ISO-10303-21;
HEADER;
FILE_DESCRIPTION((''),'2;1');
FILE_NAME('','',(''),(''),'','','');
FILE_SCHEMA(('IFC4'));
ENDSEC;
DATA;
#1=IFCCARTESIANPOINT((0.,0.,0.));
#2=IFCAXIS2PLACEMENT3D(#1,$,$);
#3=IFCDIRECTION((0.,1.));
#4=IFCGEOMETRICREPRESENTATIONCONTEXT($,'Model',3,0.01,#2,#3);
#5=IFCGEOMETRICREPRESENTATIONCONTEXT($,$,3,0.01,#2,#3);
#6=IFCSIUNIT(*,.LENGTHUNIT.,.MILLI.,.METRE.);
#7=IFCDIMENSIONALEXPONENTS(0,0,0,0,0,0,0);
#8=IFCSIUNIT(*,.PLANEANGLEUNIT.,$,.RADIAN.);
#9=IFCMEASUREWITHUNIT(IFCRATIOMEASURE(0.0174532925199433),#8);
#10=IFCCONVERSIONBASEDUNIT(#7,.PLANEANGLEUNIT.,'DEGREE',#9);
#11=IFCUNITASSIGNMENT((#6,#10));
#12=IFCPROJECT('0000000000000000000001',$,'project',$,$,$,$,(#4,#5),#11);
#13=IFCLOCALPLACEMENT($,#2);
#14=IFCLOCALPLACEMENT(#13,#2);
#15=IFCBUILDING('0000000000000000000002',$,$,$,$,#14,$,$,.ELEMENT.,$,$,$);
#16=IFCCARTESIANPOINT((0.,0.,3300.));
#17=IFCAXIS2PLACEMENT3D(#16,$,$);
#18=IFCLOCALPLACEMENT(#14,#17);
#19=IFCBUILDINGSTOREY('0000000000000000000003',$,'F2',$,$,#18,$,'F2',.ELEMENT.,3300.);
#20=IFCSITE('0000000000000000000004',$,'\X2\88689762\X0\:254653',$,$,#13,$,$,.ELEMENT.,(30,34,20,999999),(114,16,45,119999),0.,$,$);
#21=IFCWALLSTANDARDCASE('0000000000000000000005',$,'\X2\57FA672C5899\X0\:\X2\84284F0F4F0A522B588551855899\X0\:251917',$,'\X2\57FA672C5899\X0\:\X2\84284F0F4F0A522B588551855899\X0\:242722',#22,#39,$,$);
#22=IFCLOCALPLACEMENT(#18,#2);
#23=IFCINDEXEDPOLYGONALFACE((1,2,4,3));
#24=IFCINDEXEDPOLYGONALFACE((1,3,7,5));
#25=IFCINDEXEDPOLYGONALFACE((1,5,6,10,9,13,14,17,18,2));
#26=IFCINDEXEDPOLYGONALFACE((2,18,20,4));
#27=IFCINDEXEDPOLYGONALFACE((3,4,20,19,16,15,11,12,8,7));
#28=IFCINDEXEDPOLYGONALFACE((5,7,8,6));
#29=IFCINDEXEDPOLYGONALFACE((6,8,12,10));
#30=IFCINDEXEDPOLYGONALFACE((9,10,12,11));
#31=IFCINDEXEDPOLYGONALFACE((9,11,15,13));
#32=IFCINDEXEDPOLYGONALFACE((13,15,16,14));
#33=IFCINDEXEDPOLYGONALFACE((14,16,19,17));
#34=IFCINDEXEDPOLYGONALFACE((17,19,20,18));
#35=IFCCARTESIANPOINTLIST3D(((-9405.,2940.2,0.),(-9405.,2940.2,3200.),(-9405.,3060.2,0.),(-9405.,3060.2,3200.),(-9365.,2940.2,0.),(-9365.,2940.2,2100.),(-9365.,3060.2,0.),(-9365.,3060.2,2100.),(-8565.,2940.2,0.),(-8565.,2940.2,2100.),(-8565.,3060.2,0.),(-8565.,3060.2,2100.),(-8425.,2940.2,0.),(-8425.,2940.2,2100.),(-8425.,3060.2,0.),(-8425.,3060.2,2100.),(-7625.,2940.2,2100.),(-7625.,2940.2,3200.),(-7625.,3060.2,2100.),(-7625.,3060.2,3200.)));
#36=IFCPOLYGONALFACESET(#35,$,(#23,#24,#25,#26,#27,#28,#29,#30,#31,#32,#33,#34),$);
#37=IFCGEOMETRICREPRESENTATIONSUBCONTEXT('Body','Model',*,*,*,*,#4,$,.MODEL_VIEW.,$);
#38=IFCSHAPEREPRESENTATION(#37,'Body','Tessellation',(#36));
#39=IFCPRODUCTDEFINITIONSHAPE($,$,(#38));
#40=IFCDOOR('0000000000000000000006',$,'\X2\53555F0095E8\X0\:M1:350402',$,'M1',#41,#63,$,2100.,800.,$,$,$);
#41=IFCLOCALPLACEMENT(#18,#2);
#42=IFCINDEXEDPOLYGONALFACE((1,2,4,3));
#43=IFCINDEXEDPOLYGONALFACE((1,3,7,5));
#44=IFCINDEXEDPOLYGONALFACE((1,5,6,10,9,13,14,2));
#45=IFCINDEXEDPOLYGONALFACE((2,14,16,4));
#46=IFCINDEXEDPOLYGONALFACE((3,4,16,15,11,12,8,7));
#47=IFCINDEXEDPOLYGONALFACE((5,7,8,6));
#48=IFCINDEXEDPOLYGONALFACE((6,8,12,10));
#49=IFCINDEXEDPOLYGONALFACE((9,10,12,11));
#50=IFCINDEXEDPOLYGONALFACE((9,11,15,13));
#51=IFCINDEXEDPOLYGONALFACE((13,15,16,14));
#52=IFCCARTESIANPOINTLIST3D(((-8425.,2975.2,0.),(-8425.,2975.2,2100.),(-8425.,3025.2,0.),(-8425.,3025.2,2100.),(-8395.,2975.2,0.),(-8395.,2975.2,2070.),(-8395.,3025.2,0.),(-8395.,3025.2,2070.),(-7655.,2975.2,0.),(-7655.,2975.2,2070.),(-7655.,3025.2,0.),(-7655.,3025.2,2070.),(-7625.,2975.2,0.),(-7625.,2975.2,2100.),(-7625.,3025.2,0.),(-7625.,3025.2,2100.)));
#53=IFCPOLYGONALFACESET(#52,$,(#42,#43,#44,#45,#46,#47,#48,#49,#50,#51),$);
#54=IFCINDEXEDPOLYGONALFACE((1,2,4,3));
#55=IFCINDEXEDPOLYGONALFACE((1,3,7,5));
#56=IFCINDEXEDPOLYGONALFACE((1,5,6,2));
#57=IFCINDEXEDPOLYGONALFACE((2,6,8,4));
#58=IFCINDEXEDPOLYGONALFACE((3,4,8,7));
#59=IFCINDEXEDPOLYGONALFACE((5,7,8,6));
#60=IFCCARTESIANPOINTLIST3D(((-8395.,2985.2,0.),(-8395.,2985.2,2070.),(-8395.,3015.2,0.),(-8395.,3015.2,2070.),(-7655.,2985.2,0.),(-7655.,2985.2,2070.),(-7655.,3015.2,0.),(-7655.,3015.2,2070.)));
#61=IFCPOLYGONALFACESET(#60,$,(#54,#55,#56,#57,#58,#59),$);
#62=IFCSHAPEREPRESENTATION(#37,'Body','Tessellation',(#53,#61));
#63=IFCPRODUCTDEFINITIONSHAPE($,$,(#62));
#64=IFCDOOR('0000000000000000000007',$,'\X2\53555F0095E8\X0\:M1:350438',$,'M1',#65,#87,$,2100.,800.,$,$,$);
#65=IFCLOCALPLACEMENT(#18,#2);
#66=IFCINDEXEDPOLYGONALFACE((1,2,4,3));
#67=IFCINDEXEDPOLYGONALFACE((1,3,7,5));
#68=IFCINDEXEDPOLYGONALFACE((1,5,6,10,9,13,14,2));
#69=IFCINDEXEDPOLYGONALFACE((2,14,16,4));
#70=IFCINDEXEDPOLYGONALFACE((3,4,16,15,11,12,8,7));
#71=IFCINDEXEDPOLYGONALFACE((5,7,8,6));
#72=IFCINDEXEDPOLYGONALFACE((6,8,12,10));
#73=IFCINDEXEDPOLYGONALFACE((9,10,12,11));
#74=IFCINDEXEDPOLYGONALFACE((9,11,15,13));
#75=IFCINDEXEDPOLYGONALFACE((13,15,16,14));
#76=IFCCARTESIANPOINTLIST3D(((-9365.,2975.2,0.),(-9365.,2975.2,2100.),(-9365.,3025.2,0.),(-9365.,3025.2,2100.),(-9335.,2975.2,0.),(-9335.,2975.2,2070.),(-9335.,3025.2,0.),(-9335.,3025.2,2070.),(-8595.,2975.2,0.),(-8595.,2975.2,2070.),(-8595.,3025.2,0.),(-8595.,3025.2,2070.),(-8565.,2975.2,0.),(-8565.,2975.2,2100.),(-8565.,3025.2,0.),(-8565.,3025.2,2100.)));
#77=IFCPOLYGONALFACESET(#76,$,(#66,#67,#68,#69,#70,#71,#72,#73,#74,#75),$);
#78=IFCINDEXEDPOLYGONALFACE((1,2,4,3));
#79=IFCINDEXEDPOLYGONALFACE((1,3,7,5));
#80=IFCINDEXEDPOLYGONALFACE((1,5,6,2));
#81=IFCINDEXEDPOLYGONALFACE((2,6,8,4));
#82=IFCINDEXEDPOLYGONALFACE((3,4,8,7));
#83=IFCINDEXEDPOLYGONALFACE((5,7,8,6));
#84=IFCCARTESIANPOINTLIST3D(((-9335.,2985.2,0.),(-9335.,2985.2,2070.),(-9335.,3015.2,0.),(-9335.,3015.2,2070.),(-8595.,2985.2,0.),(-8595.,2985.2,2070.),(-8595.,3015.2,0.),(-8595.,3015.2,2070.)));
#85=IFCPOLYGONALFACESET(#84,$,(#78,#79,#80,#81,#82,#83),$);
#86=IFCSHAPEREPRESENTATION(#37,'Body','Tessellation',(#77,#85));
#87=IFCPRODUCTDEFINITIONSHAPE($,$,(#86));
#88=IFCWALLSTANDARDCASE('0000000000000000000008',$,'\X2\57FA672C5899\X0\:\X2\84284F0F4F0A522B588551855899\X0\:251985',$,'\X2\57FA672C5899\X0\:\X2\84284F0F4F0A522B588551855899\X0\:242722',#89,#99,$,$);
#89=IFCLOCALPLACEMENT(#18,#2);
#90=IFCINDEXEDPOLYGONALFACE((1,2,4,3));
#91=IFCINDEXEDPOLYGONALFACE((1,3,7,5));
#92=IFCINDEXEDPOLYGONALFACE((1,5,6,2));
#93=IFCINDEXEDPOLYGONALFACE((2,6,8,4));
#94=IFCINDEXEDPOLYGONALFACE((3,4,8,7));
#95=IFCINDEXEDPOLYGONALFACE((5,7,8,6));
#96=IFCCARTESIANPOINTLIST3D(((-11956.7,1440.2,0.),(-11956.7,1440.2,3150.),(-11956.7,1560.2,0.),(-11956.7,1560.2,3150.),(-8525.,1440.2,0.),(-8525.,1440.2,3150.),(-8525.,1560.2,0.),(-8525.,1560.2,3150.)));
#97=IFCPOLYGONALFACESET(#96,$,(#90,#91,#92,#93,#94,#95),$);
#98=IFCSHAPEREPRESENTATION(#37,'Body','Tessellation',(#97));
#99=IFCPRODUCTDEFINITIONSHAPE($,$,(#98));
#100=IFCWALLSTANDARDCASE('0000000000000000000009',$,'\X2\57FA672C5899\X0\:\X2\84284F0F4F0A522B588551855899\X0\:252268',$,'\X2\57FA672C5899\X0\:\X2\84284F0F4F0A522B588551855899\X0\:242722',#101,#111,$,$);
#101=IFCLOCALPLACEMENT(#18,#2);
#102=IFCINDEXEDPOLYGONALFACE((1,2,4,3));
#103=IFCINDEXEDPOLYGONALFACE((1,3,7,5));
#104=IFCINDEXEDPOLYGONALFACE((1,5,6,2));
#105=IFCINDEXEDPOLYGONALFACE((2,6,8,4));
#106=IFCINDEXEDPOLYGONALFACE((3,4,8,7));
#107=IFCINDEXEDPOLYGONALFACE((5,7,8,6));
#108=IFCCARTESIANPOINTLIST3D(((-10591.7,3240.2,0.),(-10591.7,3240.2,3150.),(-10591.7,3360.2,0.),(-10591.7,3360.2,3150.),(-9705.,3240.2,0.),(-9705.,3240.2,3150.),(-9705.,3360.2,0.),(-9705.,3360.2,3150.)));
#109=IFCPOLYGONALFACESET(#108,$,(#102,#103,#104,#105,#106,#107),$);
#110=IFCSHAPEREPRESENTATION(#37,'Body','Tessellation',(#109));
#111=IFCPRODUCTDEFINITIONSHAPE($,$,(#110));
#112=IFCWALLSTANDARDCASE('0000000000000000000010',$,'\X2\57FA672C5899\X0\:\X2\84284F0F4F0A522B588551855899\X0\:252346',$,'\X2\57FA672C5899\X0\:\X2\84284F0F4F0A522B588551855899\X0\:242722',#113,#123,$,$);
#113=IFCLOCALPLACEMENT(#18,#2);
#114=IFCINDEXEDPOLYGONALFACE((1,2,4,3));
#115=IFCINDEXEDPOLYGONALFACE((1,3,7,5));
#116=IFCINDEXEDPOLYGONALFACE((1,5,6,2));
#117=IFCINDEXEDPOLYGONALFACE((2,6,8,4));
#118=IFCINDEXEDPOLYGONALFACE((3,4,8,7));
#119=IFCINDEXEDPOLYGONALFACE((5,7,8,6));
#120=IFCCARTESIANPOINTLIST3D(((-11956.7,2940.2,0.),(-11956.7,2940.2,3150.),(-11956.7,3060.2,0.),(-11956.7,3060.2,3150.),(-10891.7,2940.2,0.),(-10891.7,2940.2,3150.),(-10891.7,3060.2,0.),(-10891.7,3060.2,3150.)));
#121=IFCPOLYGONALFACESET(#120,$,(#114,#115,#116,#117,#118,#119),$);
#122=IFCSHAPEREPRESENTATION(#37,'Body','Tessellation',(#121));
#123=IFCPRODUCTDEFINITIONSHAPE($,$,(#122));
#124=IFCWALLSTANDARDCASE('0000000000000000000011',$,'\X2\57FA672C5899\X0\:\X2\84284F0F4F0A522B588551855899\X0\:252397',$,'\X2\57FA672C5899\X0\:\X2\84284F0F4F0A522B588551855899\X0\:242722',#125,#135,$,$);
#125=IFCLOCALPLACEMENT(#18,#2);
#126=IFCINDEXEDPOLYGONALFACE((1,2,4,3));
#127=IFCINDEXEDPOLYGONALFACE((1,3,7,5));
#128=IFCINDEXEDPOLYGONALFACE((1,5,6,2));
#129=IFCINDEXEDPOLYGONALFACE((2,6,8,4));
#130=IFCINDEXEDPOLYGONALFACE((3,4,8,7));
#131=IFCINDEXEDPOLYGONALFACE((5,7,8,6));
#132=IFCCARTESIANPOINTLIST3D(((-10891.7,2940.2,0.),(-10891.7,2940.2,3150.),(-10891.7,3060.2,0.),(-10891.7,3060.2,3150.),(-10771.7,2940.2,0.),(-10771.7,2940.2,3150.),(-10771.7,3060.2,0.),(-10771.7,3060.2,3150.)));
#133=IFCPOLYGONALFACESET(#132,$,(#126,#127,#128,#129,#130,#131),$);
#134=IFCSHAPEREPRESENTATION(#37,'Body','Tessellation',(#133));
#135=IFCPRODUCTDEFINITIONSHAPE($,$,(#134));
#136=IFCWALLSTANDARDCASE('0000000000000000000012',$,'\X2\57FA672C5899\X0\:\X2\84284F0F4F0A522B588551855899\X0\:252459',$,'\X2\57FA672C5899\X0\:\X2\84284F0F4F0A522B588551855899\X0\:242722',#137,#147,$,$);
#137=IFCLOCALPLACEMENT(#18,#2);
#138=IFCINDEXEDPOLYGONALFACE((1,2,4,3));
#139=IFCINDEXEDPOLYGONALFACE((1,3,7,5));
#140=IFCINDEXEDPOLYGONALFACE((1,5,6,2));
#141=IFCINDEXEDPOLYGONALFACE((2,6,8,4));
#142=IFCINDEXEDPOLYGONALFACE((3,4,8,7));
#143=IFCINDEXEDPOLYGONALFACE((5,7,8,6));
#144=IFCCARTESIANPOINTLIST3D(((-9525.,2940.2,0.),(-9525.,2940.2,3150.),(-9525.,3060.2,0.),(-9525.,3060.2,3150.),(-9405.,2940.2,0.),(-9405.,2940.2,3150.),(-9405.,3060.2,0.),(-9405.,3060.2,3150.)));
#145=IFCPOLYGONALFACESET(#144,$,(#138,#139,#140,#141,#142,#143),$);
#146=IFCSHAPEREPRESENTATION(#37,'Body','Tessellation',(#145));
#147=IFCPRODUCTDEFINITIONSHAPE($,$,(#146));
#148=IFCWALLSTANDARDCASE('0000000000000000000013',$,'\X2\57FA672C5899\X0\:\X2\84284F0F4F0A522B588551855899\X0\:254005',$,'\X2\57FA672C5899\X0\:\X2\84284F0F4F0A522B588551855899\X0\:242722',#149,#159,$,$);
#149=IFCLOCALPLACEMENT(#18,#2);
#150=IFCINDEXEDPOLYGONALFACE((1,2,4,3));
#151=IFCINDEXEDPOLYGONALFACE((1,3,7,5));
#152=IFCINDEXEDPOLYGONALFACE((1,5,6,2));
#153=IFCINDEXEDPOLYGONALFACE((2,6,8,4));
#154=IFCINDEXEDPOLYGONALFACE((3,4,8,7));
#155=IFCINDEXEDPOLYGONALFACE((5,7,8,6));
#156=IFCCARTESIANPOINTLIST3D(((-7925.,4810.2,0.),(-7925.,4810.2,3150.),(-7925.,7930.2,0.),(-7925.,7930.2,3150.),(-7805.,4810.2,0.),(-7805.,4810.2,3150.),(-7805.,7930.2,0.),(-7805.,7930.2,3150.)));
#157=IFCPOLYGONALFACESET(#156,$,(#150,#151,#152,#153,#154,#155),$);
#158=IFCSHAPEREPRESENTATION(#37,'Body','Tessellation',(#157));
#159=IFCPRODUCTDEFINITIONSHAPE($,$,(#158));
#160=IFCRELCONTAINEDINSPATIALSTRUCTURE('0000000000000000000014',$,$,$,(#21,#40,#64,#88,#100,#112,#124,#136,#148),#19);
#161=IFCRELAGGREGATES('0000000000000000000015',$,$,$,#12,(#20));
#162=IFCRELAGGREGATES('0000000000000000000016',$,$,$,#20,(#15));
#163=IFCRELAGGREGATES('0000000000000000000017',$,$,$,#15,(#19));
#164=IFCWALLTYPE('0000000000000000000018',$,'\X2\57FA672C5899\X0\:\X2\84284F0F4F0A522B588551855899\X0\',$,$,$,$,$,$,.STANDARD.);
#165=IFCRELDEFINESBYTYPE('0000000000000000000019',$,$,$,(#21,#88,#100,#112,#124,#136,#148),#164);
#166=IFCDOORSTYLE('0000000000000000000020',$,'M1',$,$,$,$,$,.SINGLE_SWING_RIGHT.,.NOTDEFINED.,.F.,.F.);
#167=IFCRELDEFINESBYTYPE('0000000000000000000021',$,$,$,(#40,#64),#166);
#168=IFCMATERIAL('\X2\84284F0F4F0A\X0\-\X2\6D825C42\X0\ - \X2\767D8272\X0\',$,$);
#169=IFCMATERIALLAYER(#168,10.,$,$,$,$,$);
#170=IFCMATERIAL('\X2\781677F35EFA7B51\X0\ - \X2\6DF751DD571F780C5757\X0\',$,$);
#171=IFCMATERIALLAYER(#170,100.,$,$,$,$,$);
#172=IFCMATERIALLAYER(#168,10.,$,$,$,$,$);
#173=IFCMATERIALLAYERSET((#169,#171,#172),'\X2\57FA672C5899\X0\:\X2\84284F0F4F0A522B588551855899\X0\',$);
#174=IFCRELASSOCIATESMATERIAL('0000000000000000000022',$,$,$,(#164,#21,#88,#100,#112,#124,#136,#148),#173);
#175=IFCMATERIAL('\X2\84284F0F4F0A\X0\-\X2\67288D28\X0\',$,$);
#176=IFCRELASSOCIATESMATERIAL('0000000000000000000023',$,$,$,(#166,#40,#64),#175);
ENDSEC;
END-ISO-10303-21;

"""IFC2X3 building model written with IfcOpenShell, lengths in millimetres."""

from ifc_helpers import new_model, entity, si_unit, converted_unit, direction, frame, frame_2d, origin, origin_2d_with_axis, place, context, subcontext, project, spatial, polyline, rectangle, outline, extrude, clip, bounded_halfspace, source, transform, mapped, material, layer, layer_set, layer_usage, type_object, type_shapes, element, fill, save


model = new_model("IFC2X3")

# Units and contexts
model_context = context("Model", 3, precision=0.01, world=origin(), true_north=direction((0.0, 1.0)))
context_of_model = context(None, 3, precision=0.01, world=origin(), true_north=direction((0.0, 1.0)))
body_context = subcontext(model_context, "Body", "Model", "MODEL_VIEW")
ifc_project = project(units=[si_unit("LENGTHUNIT", "METRE", prefix="MILLI"), converted_unit("PLANEANGLEUNIT", "DEGREE", entity("IfcRatioMeasure", 0.0174532925199433), si_unit("PLANEANGLEUNIT", "RADIAN"), dimensions=[0, 0, 0, 0, 0, 0, 0])], contexts=[model_context, context_of_model])

# Site, building, storey
site_placement = place(None, origin())
site = spatial("IfcSite", under=ifc_project, at=site_placement, Name="表面:254653", CompositionType="ELEMENT", RefLatitude=(30, 34, 20, 999999), RefLongitude=(114, 16, 45, 119999), RefElevation=0.0)
building_placement = place(site_placement, origin())
building = spatial("IfcBuilding", under=site, at=building_placement, CompositionType="ELEMENT")
storey_placement = place(building_placement, frame((0.0, 0.0, 3300.0)))
storey = spatial("IfcBuildingStorey", under=building, at=storey_placement, Name="F2", LongName="F2", CompositionType="ELEMENT", Elevation=3300.0)

# Wall, openings, doors
ifc_material_1 = material(Name="萨伏伊-涂层 - 白色")
ifc_layer_1 = layer(ifc_material_1, 10.0)
ifc_material_2 = material(Name="砖石建筑 - 混凝土砌块")
ifc_layer_2 = layer(ifc_material_2, 100.0)
ifc_layer_3 = layer(ifc_material_1, 10.0)
ifc_layer_set_1 = layer_set([ifc_layer_1, ifc_layer_2, ifc_layer_3], Name="基本墙:萨伏伊别墅内墙")
ifc_layer_usage_1 = layer_usage(ifc_layer_set_1, "AXIS2", "NEGATIVE", 60.0)
wall_type_1 = type_object("IfcWallType", Name="基本墙:萨伏伊别墅内墙", PredefinedType="STANDARD", material=ifc_layer_set_1)
wall_1_placement = place(storey_placement, frame((-7625.0, 3000.2, 0.0), z_axis=(0.0, 0.0, 1.0), x_axis=(-1.0, 0.0, 0.0)))
wall_1 = element("IfcWallStandardCase", 1, at=wall_1_placement, inside=storey, type_object=wall_type_1, material=ifc_layer_usage_1, Name="基本墙:萨伏伊别墅内墙:251917", ObjectType="基本墙:萨伏伊别墅内墙:242722", context=body_context, shape_type="SweptSolid", body=[
    extrude(rectangle(XDim=1780.0, YDim=120.0, at=frame_2d((890.0, 0.0), x_axis=(-1.0, 0.0))), origin(), (0.0, 0.0, 1.0), 3200.0),
])
opening_1_placement = place(wall_1_placement, frame((800.0, 60.0, 0.0)))
opening_1 = element("IfcOpeningElement", 2, at=opening_1_placement, cuts=wall_1, ObjectType="Opening", context=body_context, shape_type="SweptSolid", body=[
    extrude(rectangle(XDim=2100.0, YDim=800.0, at=frame_2d((1050.0, 400.0), x_axis=(1.0, 0.0))), frame((0.0, 0.0, 0.0), z_axis=(0.0, -1.0, 0.0), x_axis=(0.0, 0.0, 1.0)), (0.0, 0.0, 1.0), 120.0),
])
opening_2_placement = place(wall_1_placement, frame((1740.0, 60.0, 0.0)))
opening_2 = element("IfcOpeningElement", 3, at=opening_2_placement, cuts=wall_1, ObjectType="Opening", context=body_context, shape_type="SweptSolid", body=[
    extrude(rectangle(XDim=2100.0, YDim=800.0, at=frame_2d((1050.0, 400.0), x_axis=(1.0, 0.0))), frame((0.0, 0.0, 0.0), z_axis=(0.0, -1.0, 0.0), x_axis=(0.0, 0.0, 1.0)), (0.0, 0.0, 1.0), 120.0),
])
ifc_material_3 = material(Name="萨伏伊-木质")
door_style = type_object("IfcDoorStyle", Name="M1", ConstructionType="NOTDEFINED", OperationType="SINGLE_SWING_RIGHT", ParameterTakesPrecedence=False, Sizeable=False, material=ifc_material_3)
shared_shape_1 = source(origin(), body_context, "Body", "SweptSolid", [
    extrude(outline(polyline([(-1057.5, -400.0), (1042.5, -400.0), (1042.5, -370.0), (-1027.5, -370.0), (-1027.5, 370.0), (1042.5, 370.0), (1042.5, 400.0), (-1057.5, 400.0), (-1057.5, -400.0)])), frame((400.0, 85.0, 1042.5), z_axis=(0.0, -1.0, 0.0), x_axis=(0.0, 0.0, -1.0)), (0.0, 0.0, 1.0), 50.0),
    extrude(rectangle(XDim=740.0, YDim=30.0, at=origin_2d_with_axis()), frame((400.0, 60.0, 0.0)), (0.0, 0.0, 1.0), 2070.0),
])
type_shapes(door_style, [shared_shape_1])
door_1_placement = place(opening_1_placement, frame((0.0, 0.0, 0.0), z_axis=(0.0, 0.0, 1.0), x_axis=(-1.0, 0.0, 0.0)))
door_1 = element("IfcDoor", 4, at=door_1_placement, inside=storey, type_object=door_style, material=ifc_material_3, Name="单开门:M1:350402", ObjectType="M1", OverallHeight=2100.0, OverallWidth=800.0, context=body_context, shape_type="MappedRepresentation", body=[
    mapped(shared_shape_1, transform((0.0, 0.0, 0.0), scale=1.0)),
])
fill(opening_1, door_1)
door_2_placement = place(opening_2_placement, frame((0.0, 0.0, 0.0), z_axis=(0.0, 0.0, 1.0), x_axis=(-1.0, 0.0, 0.0)))
door_2 = element("IfcDoor", 5, at=door_2_placement, inside=storey, type_object=door_style, material=ifc_material_3, Name="单开门:M1:350438", ObjectType="M1", OverallHeight=2100.0, OverallWidth=800.0, context=body_context, shape_type="MappedRepresentation", body=[
    mapped(shared_shape_1, transform((0.0, 0.0, 0.0), scale=1.0)),
])
fill(opening_2, door_2)

# Walls
ifc_layer_usage_2 = layer_usage(ifc_layer_set_1, "AXIS2", "NEGATIVE", 60.0)
wall_2_placement = place(storey_placement, frame((-8525.0, 1500.2, 0.0), z_axis=(0.0, 0.0, 1.0), x_axis=(-1.0, 0.0, 0.0)))
element("IfcWallStandardCase", 6, at=wall_2_placement, inside=storey, type_object=wall_type_1, material=ifc_layer_usage_2, Name="基本墙:萨伏伊别墅内墙:251985", ObjectType="基本墙:萨伏伊别墅内墙:242722", context=body_context, shape_type="Clipping", body=[
    clip(extrude(rectangle(XDim=3431.7, YDim=120.0, at=frame_2d((1715.8, 0.0), x_axis=(-1.0, 0.0))), origin(), (0.0, 0.0, 1.0), 3150.0), bounded_halfspace(frame((0.0, -60.0, 3150.0), z_axis=(0.0, 0.0, -1.0), x_axis=(0.0, 1.0, 0.0)), True, frame((0.0, -60.0, 3150.0)), polyline([(0.0, 0.0), (3431.7, 0.0), (3431.7, 120.0), (0.0, 120.0), (0.0, 0.0)]))),
])
ifc_layer_usage_3 = layer_usage(ifc_layer_set_1, "AXIS2", "NEGATIVE", 60.0)
wall_3_placement = place(storey_placement, frame((-10591.7, 3300.2, 0.0)))
element("IfcWallStandardCase", 7, at=wall_3_placement, inside=storey, type_object=wall_type_1, material=ifc_layer_usage_3, Name="基本墙:萨伏伊别墅内墙:252268", ObjectType="基本墙:萨伏伊别墅内墙:242722", context=body_context, shape_type="Clipping", body=[
    clip(extrude(rectangle(XDim=886.7, YDim=120.0, at=frame_2d((443.3, 0.0), x_axis=(-1.0, 0.0))), origin(), (0.0, 0.0, 1.0), 3150.0), bounded_halfspace(frame((0.0, -60.0, 3150.0), z_axis=(0.0, 0.0, -1.0), x_axis=(0.0, -1.0, 0.0)), True, frame((0.0, -60.0, 3150.0)), polyline([(0.0, 0.0), (886.7, 0.0), (886.7, 120.0), (0.0, 120.0), (0.0, 0.0)]))),
])
ifc_layer_usage_4 = layer_usage(ifc_layer_set_1, "AXIS2", "NEGATIVE", 60.0)
wall_4_placement = place(storey_placement, frame((-10891.7, 3000.2, 0.0), z_axis=(0.0, 0.0, 1.0), x_axis=(-1.0, 0.0, 0.0)))
element("IfcWallStandardCase", 8, at=wall_4_placement, inside=storey, type_object=wall_type_1, material=ifc_layer_usage_4, Name="基本墙:萨伏伊别墅内墙:252346", ObjectType="基本墙:萨伏伊别墅内墙:242722", context=body_context, shape_type="Clipping", body=[
    clip(extrude(rectangle(XDim=1065.0, YDim=120.0, at=frame_2d((532.5, 0.0), x_axis=(-1.0, 0.0))), origin(), (0.0, 0.0, 1.0), 3150.0), bounded_halfspace(frame((0.0, -60.0, 3150.0), z_axis=(0.0, 0.0, -1.0), x_axis=(0.0, 1.0, 0.0)), True, frame((0.0, -60.0, 3150.0)), polyline([(0.0, 0.0), (1065.0, 0.0), (1065.0, 120.0), (0.0, 120.0), (0.0, 0.0)]))),
])
ifc_layer_usage_5 = layer_usage(ifc_layer_set_1, "AXIS2", "NEGATIVE", 60.0)
wall_5_placement = place(storey_placement, frame((-10831.7, 2940.2, 0.0), z_axis=(0.0, 0.0, 1.0), x_axis=(0.0, 1.0, 0.0)))
element("IfcWallStandardCase", 9, at=wall_5_placement, inside=storey, type_object=wall_type_1, material=ifc_layer_usage_5, Name="基本墙:萨伏伊别墅内墙:252397", ObjectType="基本墙:萨伏伊别墅内墙:242722", context=body_context, shape_type="Clipping", body=[
    clip(extrude(rectangle(XDim=120.0, YDim=120.0, at=frame_2d((60.0, 0.0), x_axis=(-1.0, 0.0))), origin(), (0.0, 0.0, 1.0), 3150.0), bounded_halfspace(frame((0.0, -60.0, 3150.0), z_axis=(0.0, 0.0, -1.0), x_axis=(-1.0, 0.0, 0.0)), True, frame((0.0, -60.0, 3150.0)), polyline([(0.0, 0.0), (120.0, 0.0), (120.0, 120.0), (0.0, 120.0), (0.0, 0.0)]))),
])
ifc_layer_usage_6 = layer_usage(ifc_layer_set_1, "AXIS2", "NEGATIVE", 60.0)
wall_6_placement = place(storey_placement, frame((-9465.0, 2940.2, 0.0), z_axis=(0.0, 0.0, 1.0), x_axis=(0.0, 1.0, 0.0)))
element("IfcWallStandardCase", 10, at=wall_6_placement, inside=storey, type_object=wall_type_1, material=ifc_layer_usage_6, Name="基本墙:萨伏伊别墅内墙:252459", ObjectType="基本墙:萨伏伊别墅内墙:242722", context=body_context, shape_type="Clipping", body=[
    clip(extrude(rectangle(XDim=120.0, YDim=120.0, at=frame_2d((60.0, 0.0), x_axis=(-1.0, 0.0))), origin(), (0.0, 0.0, 1.0), 3150.0), bounded_halfspace(frame((0.0, -60.0, 3150.0), z_axis=(0.0, 0.0, -1.0), x_axis=(-1.0, 0.0, 0.0)), True, frame((0.0, -60.0, 3150.0)), polyline([(0.0, 0.0), (120.0, 0.0), (120.0, 120.0), (0.0, 120.0), (0.0, 0.0)]))),
])
ifc_layer_usage_7 = layer_usage(ifc_layer_set_1, "AXIS2", "NEGATIVE", 60.0)
wall_7_placement = place(storey_placement, frame((-7865.0, 4810.2, 0.0), z_axis=(0.0, 0.0, 1.0), x_axis=(0.0, 1.0, 0.0)))
element("IfcWallStandardCase", 11, at=wall_7_placement, inside=storey, type_object=wall_type_1, material=ifc_layer_usage_7, Name="基本墙:萨伏伊别墅内墙:254005", ObjectType="基本墙:萨伏伊别墅内墙:242722", context=body_context, shape_type="Clipping", body=[
    clip(extrude(rectangle(XDim=3120.0, YDim=120.0, at=frame_2d((1560.0, 0.0), x_axis=(-1.0, 0.0))), origin(), (0.0, 0.0, 1.0), 3150.0), bounded_halfspace(frame((0.0, -60.0, 3150.0), z_axis=(0.0, 0.0, -1.0), x_axis=(-1.0, 0.0, 0.0)), True, frame((0.0, -60.0, 3150.0)), polyline([(0.0, 0.0), (3000.0, 0.0), (3120.0, 0.0), (3120.0, 120.0), (0.0, 120.0), (0.0, 0.0)]))),
])

save(model, "model.ifc")
